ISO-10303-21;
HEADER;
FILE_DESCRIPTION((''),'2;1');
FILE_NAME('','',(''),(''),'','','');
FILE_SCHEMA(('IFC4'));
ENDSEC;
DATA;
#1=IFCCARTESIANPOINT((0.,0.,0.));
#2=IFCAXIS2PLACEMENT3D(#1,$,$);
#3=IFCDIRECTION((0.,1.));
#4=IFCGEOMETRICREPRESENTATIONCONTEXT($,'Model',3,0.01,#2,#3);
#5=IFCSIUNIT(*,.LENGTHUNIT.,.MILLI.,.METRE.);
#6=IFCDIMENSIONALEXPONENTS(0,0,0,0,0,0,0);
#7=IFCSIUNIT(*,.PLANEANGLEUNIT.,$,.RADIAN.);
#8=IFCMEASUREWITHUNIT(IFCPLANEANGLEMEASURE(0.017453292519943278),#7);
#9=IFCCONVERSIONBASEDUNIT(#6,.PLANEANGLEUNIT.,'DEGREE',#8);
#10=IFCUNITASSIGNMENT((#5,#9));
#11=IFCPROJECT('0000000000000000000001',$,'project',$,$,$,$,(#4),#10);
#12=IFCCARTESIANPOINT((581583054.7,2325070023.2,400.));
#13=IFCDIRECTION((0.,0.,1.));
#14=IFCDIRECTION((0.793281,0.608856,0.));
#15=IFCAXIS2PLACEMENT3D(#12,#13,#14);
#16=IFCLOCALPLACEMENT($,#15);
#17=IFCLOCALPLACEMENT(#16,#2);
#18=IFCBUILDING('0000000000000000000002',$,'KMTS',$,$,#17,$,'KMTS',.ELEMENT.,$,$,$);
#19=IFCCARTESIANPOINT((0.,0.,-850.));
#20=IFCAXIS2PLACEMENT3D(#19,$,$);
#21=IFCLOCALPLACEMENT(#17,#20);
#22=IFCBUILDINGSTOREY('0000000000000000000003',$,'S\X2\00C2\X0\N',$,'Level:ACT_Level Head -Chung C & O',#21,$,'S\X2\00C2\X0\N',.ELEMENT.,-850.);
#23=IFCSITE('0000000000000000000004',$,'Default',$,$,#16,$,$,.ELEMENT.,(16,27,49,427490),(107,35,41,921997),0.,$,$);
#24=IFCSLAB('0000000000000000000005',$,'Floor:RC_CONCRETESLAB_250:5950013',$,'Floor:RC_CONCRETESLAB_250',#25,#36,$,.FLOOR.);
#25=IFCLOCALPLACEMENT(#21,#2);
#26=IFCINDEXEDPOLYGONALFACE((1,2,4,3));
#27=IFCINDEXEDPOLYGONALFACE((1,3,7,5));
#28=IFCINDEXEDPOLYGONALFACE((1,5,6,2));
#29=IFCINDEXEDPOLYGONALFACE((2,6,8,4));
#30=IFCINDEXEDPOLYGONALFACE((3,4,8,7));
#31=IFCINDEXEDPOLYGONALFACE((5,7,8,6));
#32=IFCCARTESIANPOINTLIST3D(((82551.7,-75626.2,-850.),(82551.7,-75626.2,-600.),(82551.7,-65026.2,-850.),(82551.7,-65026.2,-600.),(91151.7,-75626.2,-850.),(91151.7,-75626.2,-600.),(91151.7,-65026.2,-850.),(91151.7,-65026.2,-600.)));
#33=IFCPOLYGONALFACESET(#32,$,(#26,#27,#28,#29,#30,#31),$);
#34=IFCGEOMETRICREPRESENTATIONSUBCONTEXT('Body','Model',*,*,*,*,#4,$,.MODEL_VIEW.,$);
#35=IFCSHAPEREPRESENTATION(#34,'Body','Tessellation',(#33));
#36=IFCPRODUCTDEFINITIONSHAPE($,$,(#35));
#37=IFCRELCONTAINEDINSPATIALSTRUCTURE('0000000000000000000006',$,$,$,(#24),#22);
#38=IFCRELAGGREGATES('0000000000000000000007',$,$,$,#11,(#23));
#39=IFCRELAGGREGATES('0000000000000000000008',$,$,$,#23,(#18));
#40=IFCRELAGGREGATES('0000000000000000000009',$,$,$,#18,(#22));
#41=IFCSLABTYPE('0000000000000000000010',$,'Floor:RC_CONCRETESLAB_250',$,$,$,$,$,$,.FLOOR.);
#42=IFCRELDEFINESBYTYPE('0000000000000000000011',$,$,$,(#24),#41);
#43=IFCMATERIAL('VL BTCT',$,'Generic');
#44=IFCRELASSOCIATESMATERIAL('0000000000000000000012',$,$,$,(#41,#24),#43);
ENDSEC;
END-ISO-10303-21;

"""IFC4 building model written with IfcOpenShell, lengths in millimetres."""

from ifc_helpers import new_model, entity, si_unit, converted_unit, direction, frame, origin, place, context, subcontext, project, spatial, indexed_curve, outline, extrude, material, type_object, element, save


model = new_model("IFC4")

# Units and contexts
model_context = context("Model", 3, precision=0.01, world=origin(), true_north=direction((0.0, 1.0)))
body_context = subcontext(model_context, "Body", "Model", "MODEL_VIEW")
ifc_project = project(units=[si_unit("LENGTHUNIT", "METRE", prefix="MILLI"), converted_unit("PLANEANGLEUNIT", "DEGREE", entity("IfcPlaneAngleMeasure", 0.017453292519943278), si_unit("PLANEANGLEUNIT", "RADIAN"), dimensions=[0, 0, 0, 0, 0, 0, 0])], contexts=[model_context])

# Site, building, storey
site_placement = place(None, frame((581583054.7, 2325070023.2, 400.0), z_axis=(0.0, 0.0, 1.0), x_axis=(0.793281, 0.608856, 0.0)))
site = spatial("IfcSite", under=ifc_project, at=site_placement, Name="Default", CompositionType="ELEMENT", RefLatitude=(16, 27, 49, 427490), RefLongitude=(107, 35, 41, 921997), RefElevation=0.0)
building_placement = place(site_placement, origin())
building = spatial("IfcBuilding", under=site, at=building_placement, Name="KMTS", LongName="KMTS", CompositionType="ELEMENT")
storey_placement = place(building_placement, frame((0.0, 0.0, -850.0)))
storey = spatial("IfcBuildingStorey", under=building, at=storey_placement, Name="SÂN", ObjectType="Level:ACT_Level Head -Chung C & O", LongName="SÂN", CompositionType="ELEMENT", Elevation=-850.0)

# Slab
ifc_material = material(Name="VL BTCT", Category="Generic")
slab_type = type_object("IfcSlabType", Name="Floor:RC_CONCRETESLAB_250", PredefinedType="FLOOR", material=ifc_material)
slab_placement = place(storey_placement, origin())
element("IfcSlab", 1, at=slab_placement, inside=storey, type_object=slab_type, material=ifc_material, Name="Floor:RC_CONCRETESLAB_250:5950013", ObjectType="Floor:RC_CONCRETESLAB_250", PredefinedType="FLOOR", context=body_context, shape_type="SweptSolid", body=[
    extrude(outline(indexed_curve([(-5300.0, -4300.0), (5300.0, -4300.0), (5300.0, 4300.0), (-5300.0, 4300.0), (-5300.0, -4300.0)], self_intersect=False)), frame((86851.7, -70326.2, -600.0), z_axis=(0.0, 0.0, -1.0), x_axis=(0.0, 1.0, 0.0)), (0.0, 0.0, 1.0), 250.0),
])

save(model, "model.ifc")
